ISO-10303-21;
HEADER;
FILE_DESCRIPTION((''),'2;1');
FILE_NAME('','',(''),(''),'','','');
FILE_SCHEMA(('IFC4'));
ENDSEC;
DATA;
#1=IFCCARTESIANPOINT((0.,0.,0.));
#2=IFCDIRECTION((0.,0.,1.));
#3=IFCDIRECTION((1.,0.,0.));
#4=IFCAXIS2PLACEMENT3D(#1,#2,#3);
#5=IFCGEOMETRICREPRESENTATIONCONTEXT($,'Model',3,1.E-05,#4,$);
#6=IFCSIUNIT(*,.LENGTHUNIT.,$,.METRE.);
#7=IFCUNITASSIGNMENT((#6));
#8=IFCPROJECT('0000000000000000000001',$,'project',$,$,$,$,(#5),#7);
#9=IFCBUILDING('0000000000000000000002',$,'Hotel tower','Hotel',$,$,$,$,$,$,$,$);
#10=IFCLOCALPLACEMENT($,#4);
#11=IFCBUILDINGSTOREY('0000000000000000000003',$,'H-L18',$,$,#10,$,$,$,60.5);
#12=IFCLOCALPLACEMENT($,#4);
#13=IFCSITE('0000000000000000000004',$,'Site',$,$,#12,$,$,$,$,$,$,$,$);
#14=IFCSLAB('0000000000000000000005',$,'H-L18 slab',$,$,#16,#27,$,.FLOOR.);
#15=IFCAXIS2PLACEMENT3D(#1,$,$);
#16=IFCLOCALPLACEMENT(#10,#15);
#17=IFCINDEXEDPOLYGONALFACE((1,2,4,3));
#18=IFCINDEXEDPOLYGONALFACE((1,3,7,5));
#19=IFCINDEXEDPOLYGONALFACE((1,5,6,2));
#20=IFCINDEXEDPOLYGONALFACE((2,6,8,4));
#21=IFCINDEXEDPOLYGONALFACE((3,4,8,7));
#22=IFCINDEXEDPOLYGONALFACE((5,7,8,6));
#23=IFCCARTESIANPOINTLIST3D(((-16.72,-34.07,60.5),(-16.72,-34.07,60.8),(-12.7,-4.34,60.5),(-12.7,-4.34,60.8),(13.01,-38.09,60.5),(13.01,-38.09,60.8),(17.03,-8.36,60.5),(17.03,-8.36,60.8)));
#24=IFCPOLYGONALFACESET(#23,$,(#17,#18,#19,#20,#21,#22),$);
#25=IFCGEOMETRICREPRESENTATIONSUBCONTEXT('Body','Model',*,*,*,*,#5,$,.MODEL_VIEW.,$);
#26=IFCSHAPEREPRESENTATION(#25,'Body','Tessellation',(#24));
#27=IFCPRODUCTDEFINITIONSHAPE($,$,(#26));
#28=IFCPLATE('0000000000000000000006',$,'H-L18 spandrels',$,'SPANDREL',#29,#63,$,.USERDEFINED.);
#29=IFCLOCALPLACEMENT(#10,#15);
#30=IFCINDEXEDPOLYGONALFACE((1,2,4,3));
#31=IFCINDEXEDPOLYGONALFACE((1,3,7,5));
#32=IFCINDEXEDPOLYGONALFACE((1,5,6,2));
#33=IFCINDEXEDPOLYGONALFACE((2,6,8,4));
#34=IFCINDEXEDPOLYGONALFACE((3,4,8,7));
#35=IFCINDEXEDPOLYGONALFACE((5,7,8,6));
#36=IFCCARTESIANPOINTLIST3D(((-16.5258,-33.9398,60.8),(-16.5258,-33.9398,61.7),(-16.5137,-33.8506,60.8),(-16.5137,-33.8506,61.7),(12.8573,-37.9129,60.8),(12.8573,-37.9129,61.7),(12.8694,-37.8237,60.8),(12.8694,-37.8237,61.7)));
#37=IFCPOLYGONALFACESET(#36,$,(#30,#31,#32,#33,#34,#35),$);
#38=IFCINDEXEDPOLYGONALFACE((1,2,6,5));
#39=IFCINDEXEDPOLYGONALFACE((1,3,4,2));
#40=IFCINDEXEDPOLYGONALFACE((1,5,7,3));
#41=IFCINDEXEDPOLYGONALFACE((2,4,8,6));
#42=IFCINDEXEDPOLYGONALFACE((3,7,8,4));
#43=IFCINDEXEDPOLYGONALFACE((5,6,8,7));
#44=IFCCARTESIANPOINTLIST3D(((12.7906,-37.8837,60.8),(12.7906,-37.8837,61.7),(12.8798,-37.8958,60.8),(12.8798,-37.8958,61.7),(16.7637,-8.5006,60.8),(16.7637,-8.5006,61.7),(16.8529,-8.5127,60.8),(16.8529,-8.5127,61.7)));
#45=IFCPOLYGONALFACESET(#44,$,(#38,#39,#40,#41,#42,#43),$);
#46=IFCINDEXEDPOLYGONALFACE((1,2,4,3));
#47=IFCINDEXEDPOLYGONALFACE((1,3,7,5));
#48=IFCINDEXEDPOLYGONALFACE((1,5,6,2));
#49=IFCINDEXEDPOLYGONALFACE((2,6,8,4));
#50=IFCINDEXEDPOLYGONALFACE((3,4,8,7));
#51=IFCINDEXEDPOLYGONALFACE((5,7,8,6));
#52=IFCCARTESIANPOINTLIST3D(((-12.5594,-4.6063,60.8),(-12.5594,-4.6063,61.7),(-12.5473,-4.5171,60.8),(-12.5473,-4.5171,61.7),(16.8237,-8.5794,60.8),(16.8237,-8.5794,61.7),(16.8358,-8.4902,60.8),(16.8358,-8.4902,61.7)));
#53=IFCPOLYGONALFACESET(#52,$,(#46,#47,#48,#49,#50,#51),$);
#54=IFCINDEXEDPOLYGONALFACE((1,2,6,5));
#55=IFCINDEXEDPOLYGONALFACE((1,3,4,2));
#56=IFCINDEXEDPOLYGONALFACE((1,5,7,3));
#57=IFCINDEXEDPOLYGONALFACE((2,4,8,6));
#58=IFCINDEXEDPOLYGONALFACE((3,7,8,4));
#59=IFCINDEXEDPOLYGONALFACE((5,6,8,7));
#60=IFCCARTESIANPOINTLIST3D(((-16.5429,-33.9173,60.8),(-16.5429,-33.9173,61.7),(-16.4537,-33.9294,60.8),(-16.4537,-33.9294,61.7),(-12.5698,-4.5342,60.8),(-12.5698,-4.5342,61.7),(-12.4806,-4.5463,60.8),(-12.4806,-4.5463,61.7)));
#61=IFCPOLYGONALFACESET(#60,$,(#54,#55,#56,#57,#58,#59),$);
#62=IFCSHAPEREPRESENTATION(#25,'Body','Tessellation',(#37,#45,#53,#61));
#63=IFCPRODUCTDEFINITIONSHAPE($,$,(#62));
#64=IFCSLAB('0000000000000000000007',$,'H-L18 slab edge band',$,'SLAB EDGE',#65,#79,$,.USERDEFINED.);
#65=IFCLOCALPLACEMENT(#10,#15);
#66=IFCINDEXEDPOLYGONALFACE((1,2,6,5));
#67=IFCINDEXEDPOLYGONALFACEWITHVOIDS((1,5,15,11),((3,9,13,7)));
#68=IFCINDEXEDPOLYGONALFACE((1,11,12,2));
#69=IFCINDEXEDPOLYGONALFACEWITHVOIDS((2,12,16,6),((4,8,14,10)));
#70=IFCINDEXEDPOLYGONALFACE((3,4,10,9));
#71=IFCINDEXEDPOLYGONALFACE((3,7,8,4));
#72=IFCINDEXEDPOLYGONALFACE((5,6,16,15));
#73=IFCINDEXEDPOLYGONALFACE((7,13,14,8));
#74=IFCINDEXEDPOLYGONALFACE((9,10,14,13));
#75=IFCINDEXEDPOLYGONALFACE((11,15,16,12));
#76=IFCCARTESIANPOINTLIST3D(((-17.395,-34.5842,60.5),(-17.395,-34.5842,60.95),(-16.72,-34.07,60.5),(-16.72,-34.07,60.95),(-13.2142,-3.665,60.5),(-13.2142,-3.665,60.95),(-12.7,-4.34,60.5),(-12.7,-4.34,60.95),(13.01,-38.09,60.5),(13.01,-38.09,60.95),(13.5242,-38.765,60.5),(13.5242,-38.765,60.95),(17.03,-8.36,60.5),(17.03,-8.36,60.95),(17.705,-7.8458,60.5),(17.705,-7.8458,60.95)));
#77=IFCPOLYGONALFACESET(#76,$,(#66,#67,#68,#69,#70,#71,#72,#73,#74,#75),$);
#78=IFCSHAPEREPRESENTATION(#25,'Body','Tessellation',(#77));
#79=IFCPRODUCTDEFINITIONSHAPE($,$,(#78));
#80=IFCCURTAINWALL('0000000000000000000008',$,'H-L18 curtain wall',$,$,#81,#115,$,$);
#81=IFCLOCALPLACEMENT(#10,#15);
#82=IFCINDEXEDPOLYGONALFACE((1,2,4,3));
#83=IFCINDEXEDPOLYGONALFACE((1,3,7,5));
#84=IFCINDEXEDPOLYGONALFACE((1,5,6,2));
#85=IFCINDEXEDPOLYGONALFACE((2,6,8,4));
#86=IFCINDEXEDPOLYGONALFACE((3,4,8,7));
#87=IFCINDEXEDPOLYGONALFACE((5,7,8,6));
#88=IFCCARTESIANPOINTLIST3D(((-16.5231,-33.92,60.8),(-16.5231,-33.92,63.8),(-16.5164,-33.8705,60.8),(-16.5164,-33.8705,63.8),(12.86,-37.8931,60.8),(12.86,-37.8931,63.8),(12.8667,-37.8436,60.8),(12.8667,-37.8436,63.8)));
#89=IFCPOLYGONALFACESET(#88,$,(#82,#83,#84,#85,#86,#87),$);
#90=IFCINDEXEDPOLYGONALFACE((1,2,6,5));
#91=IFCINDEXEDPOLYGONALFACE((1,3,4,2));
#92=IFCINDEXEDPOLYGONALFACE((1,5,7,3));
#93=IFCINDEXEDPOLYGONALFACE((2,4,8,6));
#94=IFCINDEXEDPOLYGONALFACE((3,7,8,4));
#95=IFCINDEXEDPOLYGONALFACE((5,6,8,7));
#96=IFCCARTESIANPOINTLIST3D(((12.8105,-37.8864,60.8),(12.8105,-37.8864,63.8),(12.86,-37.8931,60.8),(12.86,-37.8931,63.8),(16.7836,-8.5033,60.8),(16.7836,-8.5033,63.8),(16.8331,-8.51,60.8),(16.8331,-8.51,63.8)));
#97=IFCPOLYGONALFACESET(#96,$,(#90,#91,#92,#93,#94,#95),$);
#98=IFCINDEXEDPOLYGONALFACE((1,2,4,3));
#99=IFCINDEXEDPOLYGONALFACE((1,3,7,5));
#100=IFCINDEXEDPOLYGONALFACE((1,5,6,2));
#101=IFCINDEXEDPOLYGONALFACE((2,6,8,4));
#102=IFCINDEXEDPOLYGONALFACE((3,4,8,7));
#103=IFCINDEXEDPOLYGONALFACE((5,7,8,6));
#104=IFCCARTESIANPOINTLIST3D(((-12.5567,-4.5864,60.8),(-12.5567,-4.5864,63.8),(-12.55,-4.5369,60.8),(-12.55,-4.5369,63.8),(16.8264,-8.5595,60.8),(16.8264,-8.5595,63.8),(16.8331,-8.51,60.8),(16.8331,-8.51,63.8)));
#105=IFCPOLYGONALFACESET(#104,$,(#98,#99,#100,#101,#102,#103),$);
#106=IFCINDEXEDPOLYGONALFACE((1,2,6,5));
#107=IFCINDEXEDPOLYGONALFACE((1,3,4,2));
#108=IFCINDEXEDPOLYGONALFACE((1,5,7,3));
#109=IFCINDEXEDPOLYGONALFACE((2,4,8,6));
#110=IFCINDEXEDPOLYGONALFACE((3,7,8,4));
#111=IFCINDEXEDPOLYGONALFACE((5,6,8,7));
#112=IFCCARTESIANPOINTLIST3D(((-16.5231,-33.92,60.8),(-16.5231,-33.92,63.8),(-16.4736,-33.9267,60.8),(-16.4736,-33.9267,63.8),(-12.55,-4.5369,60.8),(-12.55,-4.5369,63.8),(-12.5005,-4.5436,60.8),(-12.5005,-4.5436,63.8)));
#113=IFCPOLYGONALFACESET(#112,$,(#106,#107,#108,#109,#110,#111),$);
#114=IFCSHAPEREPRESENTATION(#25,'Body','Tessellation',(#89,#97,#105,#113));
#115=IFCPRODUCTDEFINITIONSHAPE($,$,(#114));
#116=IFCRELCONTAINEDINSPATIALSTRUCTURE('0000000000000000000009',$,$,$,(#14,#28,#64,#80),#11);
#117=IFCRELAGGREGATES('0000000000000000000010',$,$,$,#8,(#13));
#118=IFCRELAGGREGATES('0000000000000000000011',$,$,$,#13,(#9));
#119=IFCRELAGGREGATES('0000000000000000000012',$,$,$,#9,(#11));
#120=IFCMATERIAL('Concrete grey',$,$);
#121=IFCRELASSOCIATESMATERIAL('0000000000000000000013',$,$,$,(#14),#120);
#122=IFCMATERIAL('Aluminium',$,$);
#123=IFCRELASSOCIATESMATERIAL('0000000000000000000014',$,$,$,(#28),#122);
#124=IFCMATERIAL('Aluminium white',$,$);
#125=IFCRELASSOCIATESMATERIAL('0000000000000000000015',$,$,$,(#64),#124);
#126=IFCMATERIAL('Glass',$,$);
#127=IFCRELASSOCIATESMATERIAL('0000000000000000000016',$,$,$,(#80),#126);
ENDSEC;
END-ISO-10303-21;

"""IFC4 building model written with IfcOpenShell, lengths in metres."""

from ifc_helpers import new_model, si_unit, frame, origin_with_axes, place, context, subcontext, project, spatial, polyline, outline, extrude, material, element, save


model = new_model("IFC4")

# Units and contexts
model_context = context("Model", 3, precision=1e-05, world=origin_with_axes())
body_context = subcontext(model_context, "Body", "Model", "MODEL_VIEW")
ifc_project = project(units=[si_unit("LENGTHUNIT", "METRE")], contexts=[model_context])

# Site, building, storey
site_placement = place(None, origin_with_axes())
site = spatial("IfcSite", under=ifc_project, at=site_placement, Name="Site")
building = spatial("IfcBuilding", under=site, Name="Hotel tower", Description="Hotel")
storey_placement = place(None, origin_with_axes())
storey = spatial("IfcBuildingStorey", under=building, at=storey_placement, Name="H-L18", Elevation=60.5)

# Shared definitions
ifc_material_1 = material(Name="Aluminium")

# Slab
ifc_material_2 = material(Name="Concrete grey")
slab_1_placement = place(storey_placement, origin_with_axes())
element("IfcSlab", 1, at=slab_1_placement, inside=storey, material=ifc_material_2, Name="H-L18 slab", PredefinedType="FLOOR", context=body_context, shape_type="SweptSolid", body=[
    extrude(outline(polyline([(-16.72, -34.07), (13.01, -38.09), (17.03, -8.36), (-12.7, -4.34), (-16.72, -34.07)])), frame((0.0, 0.0, 60.5), z_axis=(0.0, 0.0, 1.0), x_axis=(1.0, 0.0, 0.0)), (0.0, 0.0, 1.0), 0.3),
])

# Plate
plate_placement = place(storey_placement, origin_with_axes())
element("IfcPlate", 2, at=plate_placement, inside=storey, material=ifc_material_1, Name="H-L18 spandrels", ObjectType="SPANDREL", PredefinedType="USERDEFINED", context=body_context, shape_type="SweptSolid", body=[
    extrude(outline(polyline([(-16.5258, -33.9398), (12.8573, -37.9129), (12.8694, -37.8237), (-16.5137, -33.8506), (-16.5258, -33.9398)])), frame((0.0, 0.0, 60.8), z_axis=(0.0, 0.0, 1.0), x_axis=(1.0, 0.0, 0.0)), (0.0, 0.0, 1.0), 0.9),
    extrude(outline(polyline([(12.8798, -37.8958), (16.8529, -8.5127), (16.7637, -8.5006), (12.7906, -37.8837), (12.8798, -37.8958)])), frame((0.0, 0.0, 60.8), z_axis=(0.0, 0.0, 1.0), x_axis=(1.0, 0.0, 0.0)), (0.0, 0.0, 1.0), 0.9),
    extrude(outline(polyline([(16.8358, -8.4902), (-12.5473, -4.5171), (-12.5594, -4.6063), (16.8237, -8.5794), (16.8358, -8.4902)])), frame((0.0, 0.0, 60.8), z_axis=(0.0, 0.0, 1.0), x_axis=(1.0, 0.0, 0.0)), (0.0, 0.0, 1.0), 0.9),
    extrude(outline(polyline([(-12.5698, -4.5342), (-16.5429, -33.9173), (-16.4537, -33.9294), (-12.4806, -4.5463), (-12.5698, -4.5342)])), frame((0.0, 0.0, 60.8), z_axis=(0.0, 0.0, 1.0), x_axis=(1.0, 0.0, 0.0)), (0.0, 0.0, 1.0), 0.9),
])

# Slab
ifc_material_3 = material(Name="Aluminium white")
slab_2_placement = place(storey_placement, origin_with_axes())
element("IfcSlab", 3, at=slab_2_placement, inside=storey, material=ifc_material_3, Name="H-L18 slab edge band", ObjectType="SLAB EDGE", PredefinedType="USERDEFINED", context=body_context, shape_type="SweptSolid", body=[
    extrude(outline(polyline([(-17.395, -34.5842), (13.5242, -38.765), (17.705, -7.8458), (-13.2142, -3.665), (-17.395, -34.5842)]), holes=[polyline([(-16.72, -34.07), (13.01, -38.09), (17.03, -8.36), (-12.7, -4.34), (-16.72, -34.07)])]), frame((0.0, 0.0, 60.5), z_axis=(0.0, 0.0, 1.0), x_axis=(1.0, 0.0, 0.0)), (0.0, 0.0, 1.0), 0.45),
])

# Curtain wall
ifc_material_4 = material(Name="Glass")
curtain_wall_placement = place(storey_placement, origin_with_axes())
element("IfcCurtainWall", 4, at=curtain_wall_placement, inside=storey, material=ifc_material_4, Name="H-L18 curtain wall", context=body_context, shape_type="SweptSolid", body=[
    extrude(outline(polyline([(-16.5231, -33.92), (12.86, -37.8931), (12.8667, -37.8436), (-16.5164, -33.8705), (-16.5231, -33.92)])), frame((0.0, 0.0, 60.8), z_axis=(0.0, 0.0, 1.0), x_axis=(1.0, 0.0, 0.0)), (0.0, 0.0, 1.0), 3.0),
    extrude(outline(polyline([(12.86, -37.8931), (16.8331, -8.51), (16.7836, -8.5033), (12.8105, -37.8864), (12.86, -37.8931)])), frame((0.0, 0.0, 60.8), z_axis=(0.0, 0.0, 1.0), x_axis=(1.0, 0.0, 0.0)), (0.0, 0.0, 1.0), 3.0),
    extrude(outline(polyline([(16.8331, -8.51), (-12.55, -4.5369), (-12.5567, -4.5864), (16.8264, -8.5595), (16.8331, -8.51)])), frame((0.0, 0.0, 60.8), z_axis=(0.0, 0.0, 1.0), x_axis=(1.0, 0.0, 0.0)), (0.0, 0.0, 1.0), 3.0),
    extrude(outline(polyline([(-12.55, -4.5369), (-16.5231, -33.92), (-16.4736, -33.9267), (-12.5005, -4.5436), (-12.55, -4.5369)])), frame((0.0, 0.0, 60.8), z_axis=(0.0, 0.0, 1.0), x_axis=(1.0, 0.0, 0.0)), (0.0, 0.0, 1.0), 3.0),
])

save(model, "model.ifc")
